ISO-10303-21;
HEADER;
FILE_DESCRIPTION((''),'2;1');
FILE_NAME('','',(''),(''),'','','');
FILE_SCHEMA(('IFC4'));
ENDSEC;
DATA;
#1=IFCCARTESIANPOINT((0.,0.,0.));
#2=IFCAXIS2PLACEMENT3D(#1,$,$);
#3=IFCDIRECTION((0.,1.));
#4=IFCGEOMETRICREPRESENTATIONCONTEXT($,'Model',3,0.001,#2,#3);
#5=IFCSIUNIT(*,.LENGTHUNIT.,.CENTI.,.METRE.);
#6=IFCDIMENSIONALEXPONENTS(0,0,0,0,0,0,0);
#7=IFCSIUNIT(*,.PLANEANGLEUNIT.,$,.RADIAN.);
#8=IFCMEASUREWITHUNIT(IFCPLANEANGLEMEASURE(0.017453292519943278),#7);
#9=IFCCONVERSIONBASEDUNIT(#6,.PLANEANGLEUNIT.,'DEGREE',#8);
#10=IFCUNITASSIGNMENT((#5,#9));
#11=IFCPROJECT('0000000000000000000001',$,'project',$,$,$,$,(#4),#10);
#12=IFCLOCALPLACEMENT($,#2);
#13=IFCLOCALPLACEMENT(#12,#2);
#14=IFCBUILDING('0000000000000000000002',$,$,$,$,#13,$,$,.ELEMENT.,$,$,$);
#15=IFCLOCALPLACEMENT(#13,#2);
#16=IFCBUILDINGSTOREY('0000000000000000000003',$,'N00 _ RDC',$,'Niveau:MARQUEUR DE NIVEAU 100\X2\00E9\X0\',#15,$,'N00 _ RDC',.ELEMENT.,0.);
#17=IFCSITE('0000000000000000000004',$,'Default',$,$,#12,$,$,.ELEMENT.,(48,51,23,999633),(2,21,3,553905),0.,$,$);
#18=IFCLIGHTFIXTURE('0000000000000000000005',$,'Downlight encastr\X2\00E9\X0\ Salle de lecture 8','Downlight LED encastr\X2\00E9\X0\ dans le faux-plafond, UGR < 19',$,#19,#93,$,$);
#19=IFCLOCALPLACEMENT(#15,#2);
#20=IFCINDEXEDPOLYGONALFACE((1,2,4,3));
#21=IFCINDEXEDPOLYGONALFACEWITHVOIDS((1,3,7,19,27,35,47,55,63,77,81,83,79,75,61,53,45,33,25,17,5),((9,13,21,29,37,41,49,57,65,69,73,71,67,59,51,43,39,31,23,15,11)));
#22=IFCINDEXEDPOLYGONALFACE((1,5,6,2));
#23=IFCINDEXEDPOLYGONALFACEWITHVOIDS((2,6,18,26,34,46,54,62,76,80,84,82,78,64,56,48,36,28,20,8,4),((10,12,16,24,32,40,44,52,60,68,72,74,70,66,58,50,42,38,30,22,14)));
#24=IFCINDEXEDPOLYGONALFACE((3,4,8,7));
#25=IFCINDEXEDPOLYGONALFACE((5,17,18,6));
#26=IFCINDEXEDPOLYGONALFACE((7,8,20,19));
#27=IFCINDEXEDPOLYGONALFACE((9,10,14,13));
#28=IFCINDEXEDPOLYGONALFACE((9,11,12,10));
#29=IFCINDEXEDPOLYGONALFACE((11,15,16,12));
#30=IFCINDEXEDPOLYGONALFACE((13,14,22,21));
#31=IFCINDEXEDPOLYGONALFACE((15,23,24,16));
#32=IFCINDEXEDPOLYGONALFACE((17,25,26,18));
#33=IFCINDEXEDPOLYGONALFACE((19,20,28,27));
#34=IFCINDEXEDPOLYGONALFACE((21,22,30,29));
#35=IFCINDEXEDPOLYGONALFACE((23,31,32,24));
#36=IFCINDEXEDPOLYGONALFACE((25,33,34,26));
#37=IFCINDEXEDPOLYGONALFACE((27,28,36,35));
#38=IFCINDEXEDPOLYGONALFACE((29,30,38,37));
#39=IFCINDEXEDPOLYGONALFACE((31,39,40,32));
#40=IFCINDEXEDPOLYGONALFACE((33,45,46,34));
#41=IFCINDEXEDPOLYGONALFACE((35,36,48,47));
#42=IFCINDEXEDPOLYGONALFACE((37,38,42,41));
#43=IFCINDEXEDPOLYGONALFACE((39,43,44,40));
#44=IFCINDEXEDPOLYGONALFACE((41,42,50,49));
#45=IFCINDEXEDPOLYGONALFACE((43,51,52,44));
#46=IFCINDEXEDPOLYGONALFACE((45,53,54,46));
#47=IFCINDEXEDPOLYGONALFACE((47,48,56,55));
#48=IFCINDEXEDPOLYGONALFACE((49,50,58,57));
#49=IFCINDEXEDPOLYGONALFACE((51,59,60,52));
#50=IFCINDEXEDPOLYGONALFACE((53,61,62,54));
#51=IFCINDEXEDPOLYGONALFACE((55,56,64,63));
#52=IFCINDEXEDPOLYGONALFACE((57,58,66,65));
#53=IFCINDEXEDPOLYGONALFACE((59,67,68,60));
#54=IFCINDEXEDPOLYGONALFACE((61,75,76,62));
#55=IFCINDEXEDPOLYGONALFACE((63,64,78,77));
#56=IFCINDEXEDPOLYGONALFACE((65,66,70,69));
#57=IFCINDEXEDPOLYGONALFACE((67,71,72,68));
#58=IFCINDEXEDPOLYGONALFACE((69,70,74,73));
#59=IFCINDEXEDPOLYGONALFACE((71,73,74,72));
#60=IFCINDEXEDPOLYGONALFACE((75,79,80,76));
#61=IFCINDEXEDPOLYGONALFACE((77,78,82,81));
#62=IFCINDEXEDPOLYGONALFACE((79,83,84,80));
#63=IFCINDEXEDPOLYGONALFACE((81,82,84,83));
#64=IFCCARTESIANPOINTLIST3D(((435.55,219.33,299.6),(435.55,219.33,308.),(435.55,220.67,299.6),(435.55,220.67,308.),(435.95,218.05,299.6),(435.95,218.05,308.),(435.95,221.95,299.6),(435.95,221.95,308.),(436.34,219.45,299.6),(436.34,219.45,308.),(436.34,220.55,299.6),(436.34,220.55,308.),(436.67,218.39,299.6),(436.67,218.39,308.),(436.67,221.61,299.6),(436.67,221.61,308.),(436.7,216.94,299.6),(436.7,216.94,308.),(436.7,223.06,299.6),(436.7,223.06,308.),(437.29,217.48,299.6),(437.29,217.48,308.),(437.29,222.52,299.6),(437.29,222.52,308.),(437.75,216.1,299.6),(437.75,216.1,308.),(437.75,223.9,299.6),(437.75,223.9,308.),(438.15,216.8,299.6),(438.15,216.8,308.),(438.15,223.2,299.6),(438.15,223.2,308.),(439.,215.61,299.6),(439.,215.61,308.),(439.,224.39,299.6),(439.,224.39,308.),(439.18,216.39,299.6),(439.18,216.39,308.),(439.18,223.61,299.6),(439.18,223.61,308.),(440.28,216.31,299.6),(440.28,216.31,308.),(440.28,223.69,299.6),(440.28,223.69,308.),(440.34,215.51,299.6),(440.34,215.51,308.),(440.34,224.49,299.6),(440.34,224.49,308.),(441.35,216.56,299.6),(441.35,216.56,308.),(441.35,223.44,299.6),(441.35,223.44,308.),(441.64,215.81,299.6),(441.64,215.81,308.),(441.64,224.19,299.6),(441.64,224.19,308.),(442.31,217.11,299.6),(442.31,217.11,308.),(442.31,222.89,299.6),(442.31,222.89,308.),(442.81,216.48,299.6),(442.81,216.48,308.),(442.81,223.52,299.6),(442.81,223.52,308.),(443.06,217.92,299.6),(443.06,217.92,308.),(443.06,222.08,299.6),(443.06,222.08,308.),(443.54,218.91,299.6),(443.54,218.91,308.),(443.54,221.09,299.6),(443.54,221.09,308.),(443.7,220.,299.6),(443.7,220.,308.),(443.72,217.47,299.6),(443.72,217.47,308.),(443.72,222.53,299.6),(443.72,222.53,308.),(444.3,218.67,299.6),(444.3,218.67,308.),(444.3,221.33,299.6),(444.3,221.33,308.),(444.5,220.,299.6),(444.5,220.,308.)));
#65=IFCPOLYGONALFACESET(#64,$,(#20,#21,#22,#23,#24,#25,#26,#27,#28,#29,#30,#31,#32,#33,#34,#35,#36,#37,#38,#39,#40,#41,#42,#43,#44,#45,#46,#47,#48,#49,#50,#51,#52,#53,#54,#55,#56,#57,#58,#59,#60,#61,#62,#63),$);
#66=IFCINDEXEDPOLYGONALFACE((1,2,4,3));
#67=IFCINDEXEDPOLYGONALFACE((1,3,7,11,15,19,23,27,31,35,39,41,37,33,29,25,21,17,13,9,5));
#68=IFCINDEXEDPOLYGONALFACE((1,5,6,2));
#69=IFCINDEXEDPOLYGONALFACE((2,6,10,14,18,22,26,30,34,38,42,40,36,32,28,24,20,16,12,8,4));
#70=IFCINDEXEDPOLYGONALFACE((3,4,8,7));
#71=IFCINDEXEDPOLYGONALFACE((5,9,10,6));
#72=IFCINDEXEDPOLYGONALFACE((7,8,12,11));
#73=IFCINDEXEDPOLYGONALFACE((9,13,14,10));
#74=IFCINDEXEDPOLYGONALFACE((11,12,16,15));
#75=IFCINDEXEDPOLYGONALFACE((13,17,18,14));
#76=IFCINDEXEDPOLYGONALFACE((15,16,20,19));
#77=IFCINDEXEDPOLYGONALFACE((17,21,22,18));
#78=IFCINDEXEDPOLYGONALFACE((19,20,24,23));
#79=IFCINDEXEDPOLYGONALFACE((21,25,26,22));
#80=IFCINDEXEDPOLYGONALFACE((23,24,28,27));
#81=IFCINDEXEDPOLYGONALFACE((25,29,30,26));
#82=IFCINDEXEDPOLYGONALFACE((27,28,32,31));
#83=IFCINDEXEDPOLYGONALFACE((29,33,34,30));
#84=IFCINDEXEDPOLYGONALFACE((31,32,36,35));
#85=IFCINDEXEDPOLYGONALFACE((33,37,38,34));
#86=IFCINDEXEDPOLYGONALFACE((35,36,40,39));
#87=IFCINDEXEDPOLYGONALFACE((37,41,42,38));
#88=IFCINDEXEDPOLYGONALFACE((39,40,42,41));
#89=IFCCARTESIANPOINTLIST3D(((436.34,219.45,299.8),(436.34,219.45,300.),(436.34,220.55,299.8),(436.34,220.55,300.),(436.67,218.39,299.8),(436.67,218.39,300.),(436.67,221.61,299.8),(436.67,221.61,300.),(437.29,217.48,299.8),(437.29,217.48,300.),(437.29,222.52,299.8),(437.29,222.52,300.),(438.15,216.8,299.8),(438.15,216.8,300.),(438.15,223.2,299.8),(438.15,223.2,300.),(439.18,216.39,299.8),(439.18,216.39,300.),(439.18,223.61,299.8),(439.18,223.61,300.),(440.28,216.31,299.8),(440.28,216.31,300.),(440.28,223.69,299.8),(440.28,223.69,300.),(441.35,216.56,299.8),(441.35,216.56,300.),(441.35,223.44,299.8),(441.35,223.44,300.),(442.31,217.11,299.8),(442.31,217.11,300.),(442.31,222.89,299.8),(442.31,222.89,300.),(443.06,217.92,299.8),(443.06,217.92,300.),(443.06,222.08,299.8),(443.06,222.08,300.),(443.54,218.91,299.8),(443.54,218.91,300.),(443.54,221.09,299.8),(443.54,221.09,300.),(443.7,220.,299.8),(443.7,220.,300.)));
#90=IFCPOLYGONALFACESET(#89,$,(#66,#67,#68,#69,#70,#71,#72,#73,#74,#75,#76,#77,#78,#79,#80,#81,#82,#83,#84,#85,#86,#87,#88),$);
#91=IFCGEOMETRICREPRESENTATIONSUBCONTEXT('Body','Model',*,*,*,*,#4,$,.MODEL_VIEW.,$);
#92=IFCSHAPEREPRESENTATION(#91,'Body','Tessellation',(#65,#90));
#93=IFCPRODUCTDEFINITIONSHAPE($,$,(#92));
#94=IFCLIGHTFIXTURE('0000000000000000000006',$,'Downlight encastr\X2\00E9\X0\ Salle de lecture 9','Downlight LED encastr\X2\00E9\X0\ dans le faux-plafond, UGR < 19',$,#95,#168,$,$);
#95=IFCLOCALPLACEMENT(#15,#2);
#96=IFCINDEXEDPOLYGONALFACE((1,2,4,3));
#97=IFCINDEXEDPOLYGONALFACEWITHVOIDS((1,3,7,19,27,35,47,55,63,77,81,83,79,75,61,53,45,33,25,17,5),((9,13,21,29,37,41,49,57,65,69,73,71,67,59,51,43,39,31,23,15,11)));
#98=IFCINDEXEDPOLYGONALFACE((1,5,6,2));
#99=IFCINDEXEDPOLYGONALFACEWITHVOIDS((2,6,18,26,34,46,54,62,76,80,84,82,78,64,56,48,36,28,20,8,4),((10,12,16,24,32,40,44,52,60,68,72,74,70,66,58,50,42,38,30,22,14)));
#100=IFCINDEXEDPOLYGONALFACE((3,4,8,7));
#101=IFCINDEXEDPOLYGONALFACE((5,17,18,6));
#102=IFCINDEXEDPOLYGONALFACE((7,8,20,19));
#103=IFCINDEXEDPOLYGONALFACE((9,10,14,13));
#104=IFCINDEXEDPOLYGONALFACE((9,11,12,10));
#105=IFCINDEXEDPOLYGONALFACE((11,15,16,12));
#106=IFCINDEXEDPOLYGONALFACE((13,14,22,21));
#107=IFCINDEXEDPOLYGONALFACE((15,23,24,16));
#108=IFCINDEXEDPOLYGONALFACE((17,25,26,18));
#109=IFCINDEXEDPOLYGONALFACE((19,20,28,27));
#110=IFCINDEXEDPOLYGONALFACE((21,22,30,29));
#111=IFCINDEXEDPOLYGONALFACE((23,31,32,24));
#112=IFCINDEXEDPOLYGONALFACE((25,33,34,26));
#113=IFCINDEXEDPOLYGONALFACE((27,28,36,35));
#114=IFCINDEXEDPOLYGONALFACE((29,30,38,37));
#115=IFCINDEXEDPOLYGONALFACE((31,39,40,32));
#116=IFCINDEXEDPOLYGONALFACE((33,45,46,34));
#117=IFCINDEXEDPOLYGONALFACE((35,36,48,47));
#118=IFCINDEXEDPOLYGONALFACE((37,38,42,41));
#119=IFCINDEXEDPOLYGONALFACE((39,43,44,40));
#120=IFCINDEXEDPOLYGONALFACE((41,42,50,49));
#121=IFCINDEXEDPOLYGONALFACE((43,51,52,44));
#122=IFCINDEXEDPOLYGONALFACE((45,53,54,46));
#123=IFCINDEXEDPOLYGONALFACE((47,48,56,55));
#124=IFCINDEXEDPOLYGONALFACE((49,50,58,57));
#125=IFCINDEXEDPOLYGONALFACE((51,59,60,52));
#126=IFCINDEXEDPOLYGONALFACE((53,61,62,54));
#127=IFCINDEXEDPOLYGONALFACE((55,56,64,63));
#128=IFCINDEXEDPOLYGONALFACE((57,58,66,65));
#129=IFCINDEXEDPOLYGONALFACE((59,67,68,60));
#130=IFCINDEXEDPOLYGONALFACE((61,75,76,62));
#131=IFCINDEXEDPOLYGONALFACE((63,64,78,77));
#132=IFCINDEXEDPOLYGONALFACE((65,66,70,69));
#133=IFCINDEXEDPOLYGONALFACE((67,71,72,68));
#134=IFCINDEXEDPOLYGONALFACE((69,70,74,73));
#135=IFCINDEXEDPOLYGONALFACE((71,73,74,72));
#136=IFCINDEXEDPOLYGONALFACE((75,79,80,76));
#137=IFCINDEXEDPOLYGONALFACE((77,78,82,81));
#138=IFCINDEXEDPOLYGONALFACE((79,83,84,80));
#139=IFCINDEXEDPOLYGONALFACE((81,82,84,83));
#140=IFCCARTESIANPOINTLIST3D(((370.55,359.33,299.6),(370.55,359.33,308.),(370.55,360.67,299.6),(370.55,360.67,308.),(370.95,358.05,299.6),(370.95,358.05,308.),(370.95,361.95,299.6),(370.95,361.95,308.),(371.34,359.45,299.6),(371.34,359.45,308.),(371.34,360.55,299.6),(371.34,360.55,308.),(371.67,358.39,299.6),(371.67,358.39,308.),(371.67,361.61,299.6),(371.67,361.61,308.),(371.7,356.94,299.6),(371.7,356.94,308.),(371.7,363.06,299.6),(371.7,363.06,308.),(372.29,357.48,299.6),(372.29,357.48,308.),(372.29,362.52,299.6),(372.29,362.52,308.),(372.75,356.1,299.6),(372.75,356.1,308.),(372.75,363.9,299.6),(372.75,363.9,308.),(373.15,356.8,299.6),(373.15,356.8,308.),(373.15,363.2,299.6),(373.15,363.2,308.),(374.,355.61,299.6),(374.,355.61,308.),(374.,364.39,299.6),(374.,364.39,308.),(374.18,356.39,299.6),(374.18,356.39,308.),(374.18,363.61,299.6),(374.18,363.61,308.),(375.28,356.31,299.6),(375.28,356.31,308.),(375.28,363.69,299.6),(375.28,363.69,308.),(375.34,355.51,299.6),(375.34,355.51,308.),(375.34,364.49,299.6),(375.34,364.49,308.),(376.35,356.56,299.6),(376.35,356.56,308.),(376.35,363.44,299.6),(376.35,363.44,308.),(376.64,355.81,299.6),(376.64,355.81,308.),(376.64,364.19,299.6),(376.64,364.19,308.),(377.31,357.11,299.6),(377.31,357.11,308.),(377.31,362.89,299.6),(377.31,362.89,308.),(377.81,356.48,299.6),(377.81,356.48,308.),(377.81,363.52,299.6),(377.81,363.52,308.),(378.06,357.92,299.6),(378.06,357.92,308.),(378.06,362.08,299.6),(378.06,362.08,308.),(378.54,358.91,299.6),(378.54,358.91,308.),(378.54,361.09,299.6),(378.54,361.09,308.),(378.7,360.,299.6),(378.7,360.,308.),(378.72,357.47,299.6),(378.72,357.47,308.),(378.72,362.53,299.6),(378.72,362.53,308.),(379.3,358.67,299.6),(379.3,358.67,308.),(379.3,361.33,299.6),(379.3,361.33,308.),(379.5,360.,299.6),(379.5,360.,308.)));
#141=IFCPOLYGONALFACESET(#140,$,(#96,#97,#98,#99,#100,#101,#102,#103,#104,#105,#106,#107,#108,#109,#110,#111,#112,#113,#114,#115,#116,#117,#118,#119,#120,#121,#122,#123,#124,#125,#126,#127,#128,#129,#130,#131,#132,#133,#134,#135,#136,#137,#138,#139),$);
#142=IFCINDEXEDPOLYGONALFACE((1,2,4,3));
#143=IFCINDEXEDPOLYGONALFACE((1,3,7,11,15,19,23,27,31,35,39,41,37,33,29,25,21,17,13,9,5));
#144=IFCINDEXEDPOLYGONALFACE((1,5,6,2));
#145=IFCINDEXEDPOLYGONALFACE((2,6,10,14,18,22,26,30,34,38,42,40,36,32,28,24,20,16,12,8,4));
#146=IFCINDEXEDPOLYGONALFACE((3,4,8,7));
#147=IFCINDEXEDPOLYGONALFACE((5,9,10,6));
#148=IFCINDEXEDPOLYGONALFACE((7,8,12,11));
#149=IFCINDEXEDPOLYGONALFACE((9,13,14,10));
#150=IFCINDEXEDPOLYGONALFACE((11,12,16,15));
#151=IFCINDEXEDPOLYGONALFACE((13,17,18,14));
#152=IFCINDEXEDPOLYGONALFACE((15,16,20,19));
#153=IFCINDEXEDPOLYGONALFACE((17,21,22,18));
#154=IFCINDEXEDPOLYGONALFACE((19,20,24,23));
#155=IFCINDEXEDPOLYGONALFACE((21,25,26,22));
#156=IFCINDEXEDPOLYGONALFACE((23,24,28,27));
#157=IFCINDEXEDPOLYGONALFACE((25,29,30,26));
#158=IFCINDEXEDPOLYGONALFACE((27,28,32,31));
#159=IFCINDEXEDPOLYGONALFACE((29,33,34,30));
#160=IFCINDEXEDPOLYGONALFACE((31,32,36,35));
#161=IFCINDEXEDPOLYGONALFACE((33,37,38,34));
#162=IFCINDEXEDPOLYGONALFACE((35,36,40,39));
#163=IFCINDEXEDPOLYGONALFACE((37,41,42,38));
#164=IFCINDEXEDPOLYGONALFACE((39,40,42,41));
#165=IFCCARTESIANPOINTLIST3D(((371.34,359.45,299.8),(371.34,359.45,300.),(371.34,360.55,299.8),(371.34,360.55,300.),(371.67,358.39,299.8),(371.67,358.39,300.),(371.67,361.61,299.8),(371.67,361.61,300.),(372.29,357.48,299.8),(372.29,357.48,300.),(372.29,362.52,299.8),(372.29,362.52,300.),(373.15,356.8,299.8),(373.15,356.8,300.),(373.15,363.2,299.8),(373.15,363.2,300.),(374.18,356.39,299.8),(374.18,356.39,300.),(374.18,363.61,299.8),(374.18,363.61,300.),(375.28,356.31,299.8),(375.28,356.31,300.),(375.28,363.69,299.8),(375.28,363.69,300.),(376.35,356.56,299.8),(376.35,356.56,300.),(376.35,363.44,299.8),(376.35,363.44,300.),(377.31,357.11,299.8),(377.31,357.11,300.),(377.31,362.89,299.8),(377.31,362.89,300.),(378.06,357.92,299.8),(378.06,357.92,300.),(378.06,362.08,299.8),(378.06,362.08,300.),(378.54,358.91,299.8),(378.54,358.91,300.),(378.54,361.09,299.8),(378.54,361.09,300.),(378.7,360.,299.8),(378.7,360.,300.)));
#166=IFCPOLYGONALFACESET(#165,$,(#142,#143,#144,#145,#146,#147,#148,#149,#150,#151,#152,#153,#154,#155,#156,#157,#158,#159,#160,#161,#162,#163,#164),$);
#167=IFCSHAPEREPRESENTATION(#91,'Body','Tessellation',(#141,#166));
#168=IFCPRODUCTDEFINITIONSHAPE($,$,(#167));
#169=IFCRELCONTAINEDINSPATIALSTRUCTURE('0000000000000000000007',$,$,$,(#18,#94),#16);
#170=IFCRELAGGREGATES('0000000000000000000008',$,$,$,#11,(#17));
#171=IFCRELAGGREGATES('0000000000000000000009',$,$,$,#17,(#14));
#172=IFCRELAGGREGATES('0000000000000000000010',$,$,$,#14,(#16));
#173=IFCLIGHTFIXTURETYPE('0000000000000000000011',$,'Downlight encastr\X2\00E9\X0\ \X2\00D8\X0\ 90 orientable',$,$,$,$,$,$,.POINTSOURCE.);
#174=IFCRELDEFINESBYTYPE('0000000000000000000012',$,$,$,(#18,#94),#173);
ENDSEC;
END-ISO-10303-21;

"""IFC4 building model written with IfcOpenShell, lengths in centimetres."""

from ifc_helpers import new_model, entity, si_unit, converted_unit, direction, frame, frame_2d, origin, origin_with_axes, place, context, subcontext, project, spatial, circle, hollow_circle, extrude, type_object, element, save


model = new_model("IFC4")

# Units and contexts
model_context = context("Model", 3, precision=0.001, world=origin(), true_north=direction((0.0, 1.0)))
body_context = subcontext(model_context, "Body", "Model", "MODEL_VIEW")
ifc_project = project(units=[si_unit("LENGTHUNIT", "METRE", prefix="CENTI"), converted_unit("PLANEANGLEUNIT", "DEGREE", entity("IfcPlaneAngleMeasure", 0.017453292519943278), si_unit("PLANEANGLEUNIT", "RADIAN"), dimensions=[0, 0, 0, 0, 0, 0, 0])], contexts=[model_context])

# Site, building, storey
site_placement = place(None, origin())
site = spatial("IfcSite", under=ifc_project, at=site_placement, Name="Default", CompositionType="ELEMENT", RefLatitude=(48, 51, 23, 999633), RefLongitude=(2, 21, 3, 553905), RefElevation=0.0)
building_placement = place(site_placement, origin())
building = spatial("IfcBuilding", under=site, at=building_placement, CompositionType="ELEMENT")
storey_placement = place(building_placement, origin())
storey = spatial("IfcBuildingStorey", under=building, at=storey_placement, Name="N00 _ RDC", ObjectType="Niveau:MARQUEUR DE NIVEAU 100é", LongName="N00 _ RDC", CompositionType="ELEMENT", Elevation=0.0)

# Light fixtures
light_fixture_type_1 = type_object("IfcLightFixtureType", Name="Downlight encastré Ø 90 orientable", PredefinedType="POINTSOURCE")
light_fixture_1_placement = place(storey_placement, origin_with_axes())
element("IfcLightFixture", 1, at=light_fixture_1_placement, inside=storey, type_object=light_fixture_type_1, Name="Downlight encastré Salle de lecture 8", Description="Downlight LED encastré dans le faux-plafond, UGR < 19", context=body_context, shape_type="SweptSolid", body=[
    extrude(hollow_circle(Radius=4.5, WallThickness=0.8, at=frame_2d((440.0, 220.0))), frame((0.0, 0.0, 299.6)), (0.0, 0.0, 1.0), 8.4),
    extrude(circle(Radius=3.7, at=frame_2d((440.0, 220.0))), frame((0.0, 0.0, 299.8)), (0.0, 0.0, 1.0), 0.2),
])
light_fixture_2_placement = place(storey_placement, origin_with_axes())
element("IfcLightFixture", 2, at=light_fixture_2_placement, inside=storey, type_object=light_fixture_type_1, Name="Downlight encastré Salle de lecture 9", Description="Downlight LED encastré dans le faux-plafond, UGR < 19", context=body_context, shape_type="SweptSolid", body=[
    extrude(hollow_circle(Radius=4.5, WallThickness=0.8, at=frame_2d((375.0, 360.0))), frame((0.0, 0.0, 299.6)), (0.0, 0.0, 1.0), 8.4),
    extrude(circle(Radius=3.7, at=frame_2d((375.0, 360.0))), frame((0.0, 0.0, 299.8)), (0.0, 0.0, 1.0), 0.2),
])

save(model, "model.ifc")
